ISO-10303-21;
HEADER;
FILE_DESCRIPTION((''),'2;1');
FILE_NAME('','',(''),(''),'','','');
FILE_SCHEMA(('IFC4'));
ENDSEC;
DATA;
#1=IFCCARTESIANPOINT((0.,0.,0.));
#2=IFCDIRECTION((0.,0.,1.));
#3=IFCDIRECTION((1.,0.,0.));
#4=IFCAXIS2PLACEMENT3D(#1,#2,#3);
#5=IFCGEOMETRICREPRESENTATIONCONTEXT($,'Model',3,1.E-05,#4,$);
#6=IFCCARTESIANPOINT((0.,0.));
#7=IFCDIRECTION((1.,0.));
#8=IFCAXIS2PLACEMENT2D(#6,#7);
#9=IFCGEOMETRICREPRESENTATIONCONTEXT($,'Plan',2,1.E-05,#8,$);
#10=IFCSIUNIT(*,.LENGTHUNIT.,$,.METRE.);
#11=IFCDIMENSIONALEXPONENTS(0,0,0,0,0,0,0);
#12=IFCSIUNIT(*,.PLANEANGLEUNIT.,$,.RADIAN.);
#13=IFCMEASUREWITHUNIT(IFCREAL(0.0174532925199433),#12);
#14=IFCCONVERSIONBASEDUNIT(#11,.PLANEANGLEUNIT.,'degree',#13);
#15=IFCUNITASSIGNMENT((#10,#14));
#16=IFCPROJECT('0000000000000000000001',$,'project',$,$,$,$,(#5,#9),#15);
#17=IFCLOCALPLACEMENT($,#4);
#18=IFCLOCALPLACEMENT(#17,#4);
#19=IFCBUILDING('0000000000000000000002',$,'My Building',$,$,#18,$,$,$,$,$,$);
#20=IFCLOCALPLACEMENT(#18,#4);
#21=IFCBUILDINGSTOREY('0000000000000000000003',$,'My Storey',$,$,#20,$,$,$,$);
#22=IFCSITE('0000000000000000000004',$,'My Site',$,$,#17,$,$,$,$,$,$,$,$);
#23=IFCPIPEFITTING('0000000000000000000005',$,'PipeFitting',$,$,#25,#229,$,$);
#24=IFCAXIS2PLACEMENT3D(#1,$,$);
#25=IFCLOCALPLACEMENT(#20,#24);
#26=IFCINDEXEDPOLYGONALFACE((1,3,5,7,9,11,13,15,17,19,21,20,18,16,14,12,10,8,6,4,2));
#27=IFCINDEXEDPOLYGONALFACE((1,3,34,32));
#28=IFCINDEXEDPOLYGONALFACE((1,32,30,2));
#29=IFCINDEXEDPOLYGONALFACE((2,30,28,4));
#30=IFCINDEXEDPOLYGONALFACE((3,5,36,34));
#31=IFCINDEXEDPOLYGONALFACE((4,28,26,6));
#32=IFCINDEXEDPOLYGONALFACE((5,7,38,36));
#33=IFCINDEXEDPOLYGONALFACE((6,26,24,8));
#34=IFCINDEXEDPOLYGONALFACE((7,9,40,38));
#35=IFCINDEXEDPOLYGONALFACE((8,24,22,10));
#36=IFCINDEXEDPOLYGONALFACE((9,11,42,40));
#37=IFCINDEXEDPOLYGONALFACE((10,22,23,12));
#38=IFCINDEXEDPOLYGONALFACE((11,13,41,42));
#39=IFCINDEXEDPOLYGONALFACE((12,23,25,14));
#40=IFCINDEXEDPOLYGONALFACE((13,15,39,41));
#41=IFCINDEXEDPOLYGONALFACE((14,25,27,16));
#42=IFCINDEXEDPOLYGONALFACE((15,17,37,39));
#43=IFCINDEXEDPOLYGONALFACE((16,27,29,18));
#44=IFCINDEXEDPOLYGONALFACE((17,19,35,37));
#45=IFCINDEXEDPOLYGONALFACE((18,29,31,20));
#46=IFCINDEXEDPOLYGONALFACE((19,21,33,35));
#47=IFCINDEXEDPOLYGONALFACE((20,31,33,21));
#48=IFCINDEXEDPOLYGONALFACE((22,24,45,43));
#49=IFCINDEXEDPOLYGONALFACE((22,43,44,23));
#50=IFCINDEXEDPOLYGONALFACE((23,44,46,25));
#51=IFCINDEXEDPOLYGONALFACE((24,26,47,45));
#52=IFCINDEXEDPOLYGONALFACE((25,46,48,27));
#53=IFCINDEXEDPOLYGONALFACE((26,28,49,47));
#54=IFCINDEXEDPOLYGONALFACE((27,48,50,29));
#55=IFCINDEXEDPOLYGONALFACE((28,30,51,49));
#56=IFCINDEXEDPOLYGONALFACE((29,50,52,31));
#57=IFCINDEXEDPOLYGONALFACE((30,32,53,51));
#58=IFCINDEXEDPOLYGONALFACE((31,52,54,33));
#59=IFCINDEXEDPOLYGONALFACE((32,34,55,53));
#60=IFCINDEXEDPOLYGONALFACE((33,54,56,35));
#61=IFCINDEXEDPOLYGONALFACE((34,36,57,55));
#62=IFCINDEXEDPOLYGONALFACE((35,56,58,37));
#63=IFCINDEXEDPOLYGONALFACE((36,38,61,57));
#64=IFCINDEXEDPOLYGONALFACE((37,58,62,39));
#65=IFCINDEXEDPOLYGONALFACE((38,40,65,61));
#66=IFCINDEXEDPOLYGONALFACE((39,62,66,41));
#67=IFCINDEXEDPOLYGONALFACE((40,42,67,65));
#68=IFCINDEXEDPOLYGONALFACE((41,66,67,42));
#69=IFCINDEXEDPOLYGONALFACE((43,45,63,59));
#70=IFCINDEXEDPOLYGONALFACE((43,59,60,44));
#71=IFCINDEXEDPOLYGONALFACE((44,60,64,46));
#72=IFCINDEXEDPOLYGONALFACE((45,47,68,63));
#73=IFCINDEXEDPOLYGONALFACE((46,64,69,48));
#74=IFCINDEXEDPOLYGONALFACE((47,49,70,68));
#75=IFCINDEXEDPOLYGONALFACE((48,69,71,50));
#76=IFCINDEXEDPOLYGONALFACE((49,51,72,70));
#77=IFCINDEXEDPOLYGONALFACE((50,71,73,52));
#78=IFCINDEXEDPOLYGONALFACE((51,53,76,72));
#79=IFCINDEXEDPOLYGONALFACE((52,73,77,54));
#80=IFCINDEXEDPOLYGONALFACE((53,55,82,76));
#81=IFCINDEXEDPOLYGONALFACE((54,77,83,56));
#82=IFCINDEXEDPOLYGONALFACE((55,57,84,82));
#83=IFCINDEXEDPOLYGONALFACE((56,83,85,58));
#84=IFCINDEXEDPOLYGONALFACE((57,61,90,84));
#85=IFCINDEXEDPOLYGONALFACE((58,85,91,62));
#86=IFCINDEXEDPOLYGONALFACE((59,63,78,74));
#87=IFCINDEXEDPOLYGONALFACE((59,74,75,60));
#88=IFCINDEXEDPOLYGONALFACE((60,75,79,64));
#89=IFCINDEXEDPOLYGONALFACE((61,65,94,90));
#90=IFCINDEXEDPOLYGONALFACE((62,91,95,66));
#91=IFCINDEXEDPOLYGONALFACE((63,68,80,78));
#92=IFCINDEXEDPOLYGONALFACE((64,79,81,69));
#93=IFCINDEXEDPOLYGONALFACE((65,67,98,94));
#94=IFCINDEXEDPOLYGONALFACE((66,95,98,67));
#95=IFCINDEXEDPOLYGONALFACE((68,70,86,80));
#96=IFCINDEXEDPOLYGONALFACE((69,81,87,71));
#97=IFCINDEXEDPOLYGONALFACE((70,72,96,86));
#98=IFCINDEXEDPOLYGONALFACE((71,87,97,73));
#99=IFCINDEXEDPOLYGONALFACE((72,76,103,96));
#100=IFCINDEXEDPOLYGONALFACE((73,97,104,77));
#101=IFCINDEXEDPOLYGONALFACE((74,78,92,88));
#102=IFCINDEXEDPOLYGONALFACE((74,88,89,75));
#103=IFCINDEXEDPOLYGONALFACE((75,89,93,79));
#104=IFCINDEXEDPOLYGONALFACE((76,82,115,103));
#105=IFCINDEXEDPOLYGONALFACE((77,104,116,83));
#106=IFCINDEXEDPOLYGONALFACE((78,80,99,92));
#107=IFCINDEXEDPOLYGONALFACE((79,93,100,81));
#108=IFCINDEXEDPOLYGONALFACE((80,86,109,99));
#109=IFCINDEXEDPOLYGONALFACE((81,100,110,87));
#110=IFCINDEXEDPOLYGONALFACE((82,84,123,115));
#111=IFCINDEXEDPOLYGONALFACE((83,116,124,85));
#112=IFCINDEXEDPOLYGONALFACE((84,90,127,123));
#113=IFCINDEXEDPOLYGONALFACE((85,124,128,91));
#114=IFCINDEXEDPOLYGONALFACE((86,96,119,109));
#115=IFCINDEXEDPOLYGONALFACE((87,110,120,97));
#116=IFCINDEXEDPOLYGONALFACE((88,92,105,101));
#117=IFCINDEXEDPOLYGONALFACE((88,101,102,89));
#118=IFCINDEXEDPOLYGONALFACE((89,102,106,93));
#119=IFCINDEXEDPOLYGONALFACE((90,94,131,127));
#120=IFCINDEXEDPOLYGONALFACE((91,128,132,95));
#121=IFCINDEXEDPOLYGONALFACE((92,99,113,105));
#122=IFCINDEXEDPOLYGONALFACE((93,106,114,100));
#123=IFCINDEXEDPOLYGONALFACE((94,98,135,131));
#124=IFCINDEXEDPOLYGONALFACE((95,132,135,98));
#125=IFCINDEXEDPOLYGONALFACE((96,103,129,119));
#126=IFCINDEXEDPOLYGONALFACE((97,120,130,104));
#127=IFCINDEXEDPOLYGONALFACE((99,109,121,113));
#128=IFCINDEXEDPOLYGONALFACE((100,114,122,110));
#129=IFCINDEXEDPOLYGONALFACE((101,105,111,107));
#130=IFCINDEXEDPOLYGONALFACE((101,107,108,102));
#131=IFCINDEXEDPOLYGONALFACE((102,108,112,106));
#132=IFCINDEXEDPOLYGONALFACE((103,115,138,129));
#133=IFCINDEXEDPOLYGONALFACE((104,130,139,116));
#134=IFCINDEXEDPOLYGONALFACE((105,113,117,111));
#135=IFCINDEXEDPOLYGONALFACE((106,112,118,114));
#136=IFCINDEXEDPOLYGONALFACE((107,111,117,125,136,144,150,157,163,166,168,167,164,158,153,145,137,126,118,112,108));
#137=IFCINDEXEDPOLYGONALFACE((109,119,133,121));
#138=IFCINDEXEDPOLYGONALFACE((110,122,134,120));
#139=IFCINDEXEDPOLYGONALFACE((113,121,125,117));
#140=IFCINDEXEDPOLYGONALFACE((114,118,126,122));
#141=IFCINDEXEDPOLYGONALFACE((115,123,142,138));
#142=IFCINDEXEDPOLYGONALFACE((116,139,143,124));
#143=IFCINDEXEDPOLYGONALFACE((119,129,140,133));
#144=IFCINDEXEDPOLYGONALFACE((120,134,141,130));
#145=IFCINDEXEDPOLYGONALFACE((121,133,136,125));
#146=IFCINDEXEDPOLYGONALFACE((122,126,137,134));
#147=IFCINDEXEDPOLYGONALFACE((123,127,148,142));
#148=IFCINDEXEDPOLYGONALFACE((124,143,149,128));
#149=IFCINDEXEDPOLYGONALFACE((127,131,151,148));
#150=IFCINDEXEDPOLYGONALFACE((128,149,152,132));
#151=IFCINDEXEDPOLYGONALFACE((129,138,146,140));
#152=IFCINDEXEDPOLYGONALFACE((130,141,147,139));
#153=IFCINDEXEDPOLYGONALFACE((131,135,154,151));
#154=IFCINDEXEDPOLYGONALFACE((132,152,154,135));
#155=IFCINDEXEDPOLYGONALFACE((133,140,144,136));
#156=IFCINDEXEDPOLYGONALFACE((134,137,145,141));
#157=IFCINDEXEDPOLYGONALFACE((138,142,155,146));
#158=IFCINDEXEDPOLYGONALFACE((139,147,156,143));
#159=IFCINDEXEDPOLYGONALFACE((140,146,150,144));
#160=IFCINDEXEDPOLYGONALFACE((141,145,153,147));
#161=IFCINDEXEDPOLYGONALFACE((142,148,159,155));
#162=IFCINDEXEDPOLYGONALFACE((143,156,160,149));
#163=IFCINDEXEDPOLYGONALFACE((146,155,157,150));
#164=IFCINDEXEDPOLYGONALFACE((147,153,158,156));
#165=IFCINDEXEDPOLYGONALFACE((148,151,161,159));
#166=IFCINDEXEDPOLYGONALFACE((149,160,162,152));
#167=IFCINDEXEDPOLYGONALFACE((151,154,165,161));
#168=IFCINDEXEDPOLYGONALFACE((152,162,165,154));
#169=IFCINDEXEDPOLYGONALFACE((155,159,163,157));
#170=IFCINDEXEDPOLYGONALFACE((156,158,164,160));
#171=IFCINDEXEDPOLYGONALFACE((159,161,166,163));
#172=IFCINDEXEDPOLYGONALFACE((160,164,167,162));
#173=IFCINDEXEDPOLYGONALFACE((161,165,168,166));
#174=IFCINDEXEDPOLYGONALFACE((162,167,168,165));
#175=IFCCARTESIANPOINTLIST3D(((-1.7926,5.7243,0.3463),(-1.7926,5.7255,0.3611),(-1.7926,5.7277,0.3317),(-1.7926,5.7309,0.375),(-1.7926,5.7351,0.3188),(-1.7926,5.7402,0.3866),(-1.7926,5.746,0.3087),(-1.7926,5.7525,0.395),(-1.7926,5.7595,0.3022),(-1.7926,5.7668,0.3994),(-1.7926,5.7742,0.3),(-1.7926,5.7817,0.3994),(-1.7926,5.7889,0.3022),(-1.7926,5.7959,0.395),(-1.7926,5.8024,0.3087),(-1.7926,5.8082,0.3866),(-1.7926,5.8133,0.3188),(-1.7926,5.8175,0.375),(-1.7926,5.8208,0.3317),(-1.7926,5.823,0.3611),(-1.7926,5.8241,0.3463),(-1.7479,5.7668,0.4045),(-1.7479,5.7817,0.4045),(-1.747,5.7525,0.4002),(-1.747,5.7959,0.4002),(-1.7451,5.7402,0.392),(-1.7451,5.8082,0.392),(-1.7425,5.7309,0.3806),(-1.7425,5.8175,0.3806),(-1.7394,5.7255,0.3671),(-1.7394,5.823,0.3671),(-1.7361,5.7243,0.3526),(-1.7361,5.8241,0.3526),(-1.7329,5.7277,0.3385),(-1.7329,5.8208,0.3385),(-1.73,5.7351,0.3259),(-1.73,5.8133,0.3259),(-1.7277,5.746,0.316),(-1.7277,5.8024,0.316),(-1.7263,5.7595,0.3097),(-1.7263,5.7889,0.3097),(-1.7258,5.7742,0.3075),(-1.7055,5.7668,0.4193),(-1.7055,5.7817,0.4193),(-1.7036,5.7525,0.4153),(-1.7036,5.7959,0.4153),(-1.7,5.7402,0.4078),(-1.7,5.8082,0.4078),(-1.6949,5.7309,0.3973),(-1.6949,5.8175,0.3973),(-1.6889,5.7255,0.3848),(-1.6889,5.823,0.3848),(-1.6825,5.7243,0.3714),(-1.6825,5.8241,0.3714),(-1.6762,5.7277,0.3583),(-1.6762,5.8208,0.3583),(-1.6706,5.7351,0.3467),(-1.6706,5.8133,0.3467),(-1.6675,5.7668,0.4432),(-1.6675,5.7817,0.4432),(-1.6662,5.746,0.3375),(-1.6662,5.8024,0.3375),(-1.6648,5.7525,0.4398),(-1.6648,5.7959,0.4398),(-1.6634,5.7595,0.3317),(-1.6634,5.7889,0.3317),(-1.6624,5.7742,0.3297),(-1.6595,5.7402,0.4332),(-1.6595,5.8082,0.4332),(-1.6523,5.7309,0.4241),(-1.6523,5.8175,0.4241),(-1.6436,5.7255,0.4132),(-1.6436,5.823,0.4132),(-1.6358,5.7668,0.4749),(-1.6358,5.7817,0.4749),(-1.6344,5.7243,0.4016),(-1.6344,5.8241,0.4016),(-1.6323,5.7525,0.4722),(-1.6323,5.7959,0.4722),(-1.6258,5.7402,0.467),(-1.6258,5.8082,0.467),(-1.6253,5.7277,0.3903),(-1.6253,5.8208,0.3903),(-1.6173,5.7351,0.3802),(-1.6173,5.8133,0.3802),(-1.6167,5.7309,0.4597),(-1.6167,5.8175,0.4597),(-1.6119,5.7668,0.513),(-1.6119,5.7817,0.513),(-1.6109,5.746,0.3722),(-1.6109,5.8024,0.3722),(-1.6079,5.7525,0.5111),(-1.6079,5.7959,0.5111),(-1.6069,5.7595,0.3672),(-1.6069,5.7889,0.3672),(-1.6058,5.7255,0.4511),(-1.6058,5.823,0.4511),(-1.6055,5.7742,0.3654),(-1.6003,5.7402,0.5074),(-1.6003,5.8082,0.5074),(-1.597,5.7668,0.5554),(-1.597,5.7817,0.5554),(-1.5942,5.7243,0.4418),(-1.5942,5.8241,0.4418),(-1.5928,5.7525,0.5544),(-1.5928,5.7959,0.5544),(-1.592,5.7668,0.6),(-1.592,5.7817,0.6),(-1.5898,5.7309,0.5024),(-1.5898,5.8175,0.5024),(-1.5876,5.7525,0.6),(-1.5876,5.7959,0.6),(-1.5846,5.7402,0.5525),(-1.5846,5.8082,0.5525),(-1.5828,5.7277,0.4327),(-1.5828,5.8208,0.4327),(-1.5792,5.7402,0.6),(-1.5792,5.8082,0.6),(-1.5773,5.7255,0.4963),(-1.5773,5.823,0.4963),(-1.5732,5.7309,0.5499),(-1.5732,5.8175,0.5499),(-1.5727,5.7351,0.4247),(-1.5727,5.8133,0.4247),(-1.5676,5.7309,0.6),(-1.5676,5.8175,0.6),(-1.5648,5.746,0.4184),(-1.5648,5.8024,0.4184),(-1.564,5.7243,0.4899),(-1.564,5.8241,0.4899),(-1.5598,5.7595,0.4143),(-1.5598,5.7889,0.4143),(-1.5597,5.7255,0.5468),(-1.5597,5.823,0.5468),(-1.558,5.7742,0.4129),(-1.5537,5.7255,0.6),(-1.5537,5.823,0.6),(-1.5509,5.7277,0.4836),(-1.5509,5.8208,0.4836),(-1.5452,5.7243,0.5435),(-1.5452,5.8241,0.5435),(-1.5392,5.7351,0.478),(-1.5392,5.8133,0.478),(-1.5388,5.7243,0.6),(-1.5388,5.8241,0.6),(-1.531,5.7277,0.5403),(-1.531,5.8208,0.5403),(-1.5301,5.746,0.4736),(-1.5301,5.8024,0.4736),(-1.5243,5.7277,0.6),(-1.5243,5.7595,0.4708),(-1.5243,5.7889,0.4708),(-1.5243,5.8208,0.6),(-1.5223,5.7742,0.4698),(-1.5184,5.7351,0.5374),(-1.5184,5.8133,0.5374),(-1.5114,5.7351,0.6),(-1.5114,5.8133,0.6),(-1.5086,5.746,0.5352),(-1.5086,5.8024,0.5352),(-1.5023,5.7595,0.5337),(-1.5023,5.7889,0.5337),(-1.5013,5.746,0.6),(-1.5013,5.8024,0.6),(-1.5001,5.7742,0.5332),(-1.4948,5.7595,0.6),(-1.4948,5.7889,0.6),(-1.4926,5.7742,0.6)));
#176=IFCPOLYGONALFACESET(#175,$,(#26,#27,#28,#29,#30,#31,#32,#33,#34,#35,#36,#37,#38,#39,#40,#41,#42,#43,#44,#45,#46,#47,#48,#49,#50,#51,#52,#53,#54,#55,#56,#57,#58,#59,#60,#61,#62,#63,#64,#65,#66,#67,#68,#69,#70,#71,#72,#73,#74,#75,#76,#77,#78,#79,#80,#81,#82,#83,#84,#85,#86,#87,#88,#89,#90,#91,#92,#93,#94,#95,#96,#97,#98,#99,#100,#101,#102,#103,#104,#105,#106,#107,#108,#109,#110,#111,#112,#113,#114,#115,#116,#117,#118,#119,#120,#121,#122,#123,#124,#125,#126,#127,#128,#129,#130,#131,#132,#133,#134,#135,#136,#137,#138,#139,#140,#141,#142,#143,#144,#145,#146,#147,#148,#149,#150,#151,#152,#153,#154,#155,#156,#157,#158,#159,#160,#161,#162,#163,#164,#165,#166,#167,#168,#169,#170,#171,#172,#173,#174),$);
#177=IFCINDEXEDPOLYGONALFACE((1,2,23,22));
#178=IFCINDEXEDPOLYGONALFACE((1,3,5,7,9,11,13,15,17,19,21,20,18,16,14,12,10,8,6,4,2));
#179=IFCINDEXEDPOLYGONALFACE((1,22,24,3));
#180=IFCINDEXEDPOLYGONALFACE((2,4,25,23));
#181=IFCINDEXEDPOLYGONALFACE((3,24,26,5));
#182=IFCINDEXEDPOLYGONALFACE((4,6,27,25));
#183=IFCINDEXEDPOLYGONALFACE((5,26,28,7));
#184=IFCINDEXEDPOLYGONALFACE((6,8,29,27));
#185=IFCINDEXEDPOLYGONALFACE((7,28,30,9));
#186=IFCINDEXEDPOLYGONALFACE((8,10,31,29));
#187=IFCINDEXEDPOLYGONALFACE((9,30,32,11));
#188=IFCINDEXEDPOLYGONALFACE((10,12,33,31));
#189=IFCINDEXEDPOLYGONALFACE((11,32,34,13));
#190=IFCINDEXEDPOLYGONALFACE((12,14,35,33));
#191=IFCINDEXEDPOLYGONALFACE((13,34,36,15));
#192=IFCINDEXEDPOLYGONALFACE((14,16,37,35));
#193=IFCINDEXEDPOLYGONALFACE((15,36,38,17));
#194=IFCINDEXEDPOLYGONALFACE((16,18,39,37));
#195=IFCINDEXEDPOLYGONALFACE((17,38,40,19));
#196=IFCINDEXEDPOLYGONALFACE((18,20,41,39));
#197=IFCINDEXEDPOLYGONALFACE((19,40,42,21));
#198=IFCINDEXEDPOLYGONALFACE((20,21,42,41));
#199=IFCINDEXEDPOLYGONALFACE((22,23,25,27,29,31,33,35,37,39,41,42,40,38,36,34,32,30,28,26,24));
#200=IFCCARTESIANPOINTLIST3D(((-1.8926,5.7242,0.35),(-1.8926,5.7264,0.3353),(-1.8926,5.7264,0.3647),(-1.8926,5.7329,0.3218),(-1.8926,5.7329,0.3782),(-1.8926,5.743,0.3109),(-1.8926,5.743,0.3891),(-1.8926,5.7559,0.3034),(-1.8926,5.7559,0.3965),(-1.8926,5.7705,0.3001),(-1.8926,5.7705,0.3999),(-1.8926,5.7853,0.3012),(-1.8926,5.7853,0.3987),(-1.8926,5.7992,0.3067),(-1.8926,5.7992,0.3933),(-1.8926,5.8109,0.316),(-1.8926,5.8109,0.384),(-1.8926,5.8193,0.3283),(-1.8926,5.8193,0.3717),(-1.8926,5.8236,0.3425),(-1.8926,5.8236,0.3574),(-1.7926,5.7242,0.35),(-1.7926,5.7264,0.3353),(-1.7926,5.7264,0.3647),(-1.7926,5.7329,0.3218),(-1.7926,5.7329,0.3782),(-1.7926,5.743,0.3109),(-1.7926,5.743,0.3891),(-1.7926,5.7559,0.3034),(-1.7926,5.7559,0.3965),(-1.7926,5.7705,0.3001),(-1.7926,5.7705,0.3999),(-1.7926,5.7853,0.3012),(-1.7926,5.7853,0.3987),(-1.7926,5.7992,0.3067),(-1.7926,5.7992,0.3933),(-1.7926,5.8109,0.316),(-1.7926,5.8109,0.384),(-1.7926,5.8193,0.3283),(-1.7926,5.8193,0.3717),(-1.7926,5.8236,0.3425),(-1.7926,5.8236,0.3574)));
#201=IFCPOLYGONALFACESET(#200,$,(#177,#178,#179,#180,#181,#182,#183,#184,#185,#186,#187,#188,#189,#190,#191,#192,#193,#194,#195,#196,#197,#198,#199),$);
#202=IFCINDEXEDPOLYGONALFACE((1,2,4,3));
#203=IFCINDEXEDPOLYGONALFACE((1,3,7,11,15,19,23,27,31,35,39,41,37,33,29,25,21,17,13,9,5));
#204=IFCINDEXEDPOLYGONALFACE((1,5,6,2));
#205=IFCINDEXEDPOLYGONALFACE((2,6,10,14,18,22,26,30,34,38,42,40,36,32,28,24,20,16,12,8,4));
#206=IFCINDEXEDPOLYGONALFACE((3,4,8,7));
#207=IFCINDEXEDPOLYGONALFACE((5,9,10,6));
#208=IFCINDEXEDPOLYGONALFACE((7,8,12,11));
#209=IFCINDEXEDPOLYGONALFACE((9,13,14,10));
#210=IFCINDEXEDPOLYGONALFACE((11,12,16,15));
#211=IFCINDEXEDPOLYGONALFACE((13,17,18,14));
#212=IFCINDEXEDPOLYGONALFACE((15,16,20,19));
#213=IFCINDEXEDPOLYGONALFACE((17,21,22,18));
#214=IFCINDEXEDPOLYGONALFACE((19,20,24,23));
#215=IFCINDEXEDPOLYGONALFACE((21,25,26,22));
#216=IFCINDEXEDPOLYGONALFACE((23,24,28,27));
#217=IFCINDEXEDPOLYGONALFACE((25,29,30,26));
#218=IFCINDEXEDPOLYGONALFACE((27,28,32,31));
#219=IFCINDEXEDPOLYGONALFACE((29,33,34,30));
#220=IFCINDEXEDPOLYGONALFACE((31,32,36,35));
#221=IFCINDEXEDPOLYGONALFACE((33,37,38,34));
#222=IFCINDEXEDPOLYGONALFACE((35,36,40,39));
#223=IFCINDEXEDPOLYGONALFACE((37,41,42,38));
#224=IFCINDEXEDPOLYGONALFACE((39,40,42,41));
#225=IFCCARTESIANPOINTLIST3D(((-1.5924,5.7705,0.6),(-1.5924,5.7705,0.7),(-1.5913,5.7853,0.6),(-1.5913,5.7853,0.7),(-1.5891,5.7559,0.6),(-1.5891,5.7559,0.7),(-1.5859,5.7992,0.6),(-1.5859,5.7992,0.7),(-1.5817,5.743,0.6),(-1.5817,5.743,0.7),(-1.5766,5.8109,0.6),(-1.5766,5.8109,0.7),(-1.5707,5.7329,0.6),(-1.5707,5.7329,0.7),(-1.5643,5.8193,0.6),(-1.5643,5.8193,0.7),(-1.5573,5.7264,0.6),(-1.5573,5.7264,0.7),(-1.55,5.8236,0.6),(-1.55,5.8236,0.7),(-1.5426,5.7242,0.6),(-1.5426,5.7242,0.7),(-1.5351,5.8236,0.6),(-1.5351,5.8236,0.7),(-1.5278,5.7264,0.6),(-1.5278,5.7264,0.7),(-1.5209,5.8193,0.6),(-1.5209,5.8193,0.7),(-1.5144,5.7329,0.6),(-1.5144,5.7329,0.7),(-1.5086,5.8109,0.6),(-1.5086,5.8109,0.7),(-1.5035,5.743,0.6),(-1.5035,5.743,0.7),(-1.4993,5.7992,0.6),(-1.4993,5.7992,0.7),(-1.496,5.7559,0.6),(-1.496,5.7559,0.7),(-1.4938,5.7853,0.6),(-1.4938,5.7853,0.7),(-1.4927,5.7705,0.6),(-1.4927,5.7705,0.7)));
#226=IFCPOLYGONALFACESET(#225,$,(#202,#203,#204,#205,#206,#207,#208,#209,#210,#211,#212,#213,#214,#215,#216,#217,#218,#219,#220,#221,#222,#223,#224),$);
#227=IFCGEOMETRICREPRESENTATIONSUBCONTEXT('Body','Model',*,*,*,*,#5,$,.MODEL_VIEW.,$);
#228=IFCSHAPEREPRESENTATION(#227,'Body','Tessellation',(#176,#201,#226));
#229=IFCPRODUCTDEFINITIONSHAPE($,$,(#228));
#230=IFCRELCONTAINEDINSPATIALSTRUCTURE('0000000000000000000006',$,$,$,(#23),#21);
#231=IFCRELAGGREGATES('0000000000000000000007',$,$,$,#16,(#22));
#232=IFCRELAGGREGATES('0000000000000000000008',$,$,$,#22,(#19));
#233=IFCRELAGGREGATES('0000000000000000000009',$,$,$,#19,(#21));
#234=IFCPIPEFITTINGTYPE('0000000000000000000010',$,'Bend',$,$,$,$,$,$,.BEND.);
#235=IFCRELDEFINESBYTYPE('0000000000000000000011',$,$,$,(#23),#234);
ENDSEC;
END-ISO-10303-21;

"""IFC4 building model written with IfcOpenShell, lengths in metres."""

from ifc_helpers import new_model, entity, si_unit, converted_unit, frame, origin_with_axes, origin_2d_with_axis, place, context, subcontext, project, spatial, circle, extrude, source, transform, mapped, type_object, type_shapes, element, save


model = new_model("IFC4")

# Units and contexts
model_context = context("Model", 3, precision=1e-05, world=origin_with_axes())
plan_context = context("Plan", 2, precision=1e-05, world=origin_2d_with_axis())
body_context = subcontext(model_context, "Body", "Model", "MODEL_VIEW")
ifc_project = project(units=[si_unit("LENGTHUNIT", "METRE"), converted_unit("PLANEANGLEUNIT", "degree", entity("IfcReal", 0.0174532925199433), si_unit("PLANEANGLEUNIT", "RADIAN"), dimensions=[0, 0, 0, 0, 0, 0, 0])], contexts=[model_context, plan_context])

# Site, building, storey
site_placement = place(None, origin_with_axes())
site = spatial("IfcSite", under=ifc_project, at=site_placement, Name="My Site")
building_placement = place(site_placement, origin_with_axes())
building = spatial("IfcBuilding", under=site, at=building_placement, Name="My Building")
storey_placement = place(building_placement, origin_with_axes())
storey = spatial("IfcBuildingStorey", under=building, at=storey_placement, Name="My Storey")

# Pipe fitting
pipe_fitting_type_1 = type_object("IfcPipeFittingType", Name="Bend", PredefinedType="BEND")
shared_shape_1 = source(origin_with_axes(), body_context, "Body", "SolidModel", [
    entity("IfcSweptDiskSolid", entity("IfcIndexedPolyCurve", entity("IfcCartesianPointList3D", [[0.0, 0.0, 0.1], [0.0, -0.0732, 0.2768], [0.0, -0.25, 0.35]]), [entity("IfcArcIndex", [1, 2, 3])]), 0.05),
    extrude(circle(Radius=0.05), origin_with_axes(), (0.0, 0.0, 1.0), 0.1),
    extrude(circle(Radius=0.05), frame((0.0, -0.25, 0.35), z_axis=(0.0, -1.0, 0.000038), x_axis=(1.0, 0.0, 0.0)), (0.0, 0.0, 1.0), 0.1),
])
type_shapes(pipe_fitting_type_1, [shared_shape_1])
for number, where, z_axis, x_axis, name in (
    (1, (-1.8926, 5.7742, 0.35), (1.0, 0.0, 0.0), (0.0, -1.0, 0.0), "PipeFitting"),
):
    element("IfcPipeFitting", number, at=place(storey_placement, frame(where, z_axis=z_axis, x_axis=x_axis)), inside=storey, type_object=pipe_fitting_type_1, Name=name, context=body_context, shape_type="MappedRepresentation", body=[
        mapped(shared_shape_1, transform((0.0, 0.0, 0.0), x_axis=(1.0, 0.0, 0.0), y_axis=(0.0, 1.0, 0.0), z_axis=(0.0, 0.0, 1.0), scale=1.0)),
    ])

save(model, "model.ifc")
